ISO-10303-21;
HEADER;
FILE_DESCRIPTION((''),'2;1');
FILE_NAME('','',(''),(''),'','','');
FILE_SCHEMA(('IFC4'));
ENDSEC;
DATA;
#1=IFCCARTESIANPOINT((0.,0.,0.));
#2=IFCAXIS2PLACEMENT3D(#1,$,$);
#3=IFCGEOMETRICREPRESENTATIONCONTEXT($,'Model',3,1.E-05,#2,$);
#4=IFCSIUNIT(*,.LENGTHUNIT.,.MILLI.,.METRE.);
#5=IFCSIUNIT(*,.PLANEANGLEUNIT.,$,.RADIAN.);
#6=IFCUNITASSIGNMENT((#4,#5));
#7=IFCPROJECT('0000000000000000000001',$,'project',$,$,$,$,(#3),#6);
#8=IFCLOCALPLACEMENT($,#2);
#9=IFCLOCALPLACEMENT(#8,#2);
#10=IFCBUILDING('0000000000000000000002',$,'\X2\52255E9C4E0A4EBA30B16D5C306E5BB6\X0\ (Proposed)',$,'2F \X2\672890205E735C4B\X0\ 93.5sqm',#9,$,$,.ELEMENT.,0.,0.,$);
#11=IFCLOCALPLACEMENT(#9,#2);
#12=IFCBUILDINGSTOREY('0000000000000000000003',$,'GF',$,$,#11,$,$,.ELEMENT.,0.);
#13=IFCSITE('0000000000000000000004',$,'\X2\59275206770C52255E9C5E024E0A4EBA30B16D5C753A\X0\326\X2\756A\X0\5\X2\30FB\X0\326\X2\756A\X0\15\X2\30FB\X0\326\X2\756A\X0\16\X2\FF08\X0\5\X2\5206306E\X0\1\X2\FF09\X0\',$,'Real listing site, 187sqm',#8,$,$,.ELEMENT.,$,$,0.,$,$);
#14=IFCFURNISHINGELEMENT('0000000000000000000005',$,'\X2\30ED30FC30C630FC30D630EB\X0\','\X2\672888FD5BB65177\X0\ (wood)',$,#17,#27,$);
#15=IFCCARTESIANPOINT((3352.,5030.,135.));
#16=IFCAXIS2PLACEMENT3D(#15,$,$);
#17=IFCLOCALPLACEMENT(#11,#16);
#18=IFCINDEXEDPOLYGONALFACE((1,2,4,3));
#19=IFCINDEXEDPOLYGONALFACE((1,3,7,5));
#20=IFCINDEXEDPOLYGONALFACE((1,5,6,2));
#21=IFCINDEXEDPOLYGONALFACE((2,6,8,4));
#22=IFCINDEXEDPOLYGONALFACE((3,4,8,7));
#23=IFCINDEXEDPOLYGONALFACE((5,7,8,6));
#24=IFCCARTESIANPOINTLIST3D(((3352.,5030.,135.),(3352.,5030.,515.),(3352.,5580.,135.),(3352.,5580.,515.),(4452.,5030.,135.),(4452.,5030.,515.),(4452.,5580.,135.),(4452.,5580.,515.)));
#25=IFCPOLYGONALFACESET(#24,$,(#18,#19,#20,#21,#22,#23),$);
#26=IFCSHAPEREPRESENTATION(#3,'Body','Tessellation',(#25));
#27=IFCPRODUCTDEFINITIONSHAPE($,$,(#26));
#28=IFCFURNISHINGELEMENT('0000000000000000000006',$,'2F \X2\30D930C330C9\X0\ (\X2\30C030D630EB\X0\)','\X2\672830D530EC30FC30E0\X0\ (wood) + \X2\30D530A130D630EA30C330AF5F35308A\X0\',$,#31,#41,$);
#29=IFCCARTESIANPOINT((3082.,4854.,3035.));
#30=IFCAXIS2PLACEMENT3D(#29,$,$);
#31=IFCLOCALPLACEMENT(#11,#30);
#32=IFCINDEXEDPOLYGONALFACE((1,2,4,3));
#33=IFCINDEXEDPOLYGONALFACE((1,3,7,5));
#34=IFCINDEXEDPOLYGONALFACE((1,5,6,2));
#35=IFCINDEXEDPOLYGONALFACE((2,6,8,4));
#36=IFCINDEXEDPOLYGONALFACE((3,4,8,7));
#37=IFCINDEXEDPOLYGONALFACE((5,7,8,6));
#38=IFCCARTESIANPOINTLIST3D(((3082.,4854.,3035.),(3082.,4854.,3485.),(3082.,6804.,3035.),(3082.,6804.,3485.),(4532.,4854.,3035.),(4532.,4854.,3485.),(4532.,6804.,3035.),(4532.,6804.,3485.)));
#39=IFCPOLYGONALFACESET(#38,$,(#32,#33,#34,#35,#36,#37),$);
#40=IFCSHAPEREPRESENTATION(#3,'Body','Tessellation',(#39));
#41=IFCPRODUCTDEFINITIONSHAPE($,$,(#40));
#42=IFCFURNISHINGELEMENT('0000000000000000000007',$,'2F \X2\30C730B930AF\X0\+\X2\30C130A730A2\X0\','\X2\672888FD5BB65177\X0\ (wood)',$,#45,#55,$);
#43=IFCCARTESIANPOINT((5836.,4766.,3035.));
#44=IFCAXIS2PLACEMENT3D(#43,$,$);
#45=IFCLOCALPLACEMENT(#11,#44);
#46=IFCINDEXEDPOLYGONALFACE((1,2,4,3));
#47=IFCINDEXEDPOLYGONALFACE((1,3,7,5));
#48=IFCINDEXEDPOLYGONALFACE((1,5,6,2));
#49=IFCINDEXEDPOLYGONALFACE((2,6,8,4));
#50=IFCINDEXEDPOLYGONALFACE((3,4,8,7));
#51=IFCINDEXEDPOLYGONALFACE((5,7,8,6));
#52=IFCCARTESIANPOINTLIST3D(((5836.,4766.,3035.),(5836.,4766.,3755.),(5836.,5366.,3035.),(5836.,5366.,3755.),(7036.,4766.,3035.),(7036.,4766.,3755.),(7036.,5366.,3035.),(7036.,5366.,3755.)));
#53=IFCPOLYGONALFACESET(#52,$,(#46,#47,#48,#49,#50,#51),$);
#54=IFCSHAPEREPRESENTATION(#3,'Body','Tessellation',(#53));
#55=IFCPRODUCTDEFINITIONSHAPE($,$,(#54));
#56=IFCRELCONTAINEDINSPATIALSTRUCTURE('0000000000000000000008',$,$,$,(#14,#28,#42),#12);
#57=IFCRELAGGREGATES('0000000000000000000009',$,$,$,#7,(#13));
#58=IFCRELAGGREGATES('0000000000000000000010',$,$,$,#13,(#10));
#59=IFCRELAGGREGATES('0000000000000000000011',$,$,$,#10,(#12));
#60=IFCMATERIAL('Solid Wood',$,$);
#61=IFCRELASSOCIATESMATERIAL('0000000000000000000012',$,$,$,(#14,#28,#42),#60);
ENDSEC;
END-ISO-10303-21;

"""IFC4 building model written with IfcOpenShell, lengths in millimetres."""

from ifc_helpers import new_model, si_unit, frame, frame_2d, origin, place, context, project, spatial, rectangle, extrude, material, element, save


model = new_model("IFC4")

# Units and contexts
model_context = context("Model", 3, precision=1e-05, world=origin())
ifc_project = project(units=[si_unit("LENGTHUNIT", "METRE", prefix="MILLI"), si_unit("PLANEANGLEUNIT", "RADIAN")], contexts=[model_context])

# Site, building, storey
site_placement = place(None, origin())
site = spatial("IfcSite", under=ifc_project, at=site_placement, Name="大分県別府市上人ケ浜町326番5・326番15・326番16（5分の1）", ObjectType="Real listing site, 187sqm", CompositionType="ELEMENT", RefElevation=0.0)
building_placement = place(site_placement, origin())
building = spatial("IfcBuilding", under=site, at=building_placement, Name="別府上人ケ浜の家 (Proposed)", ObjectType="2F 木造平屋 93.5sqm", CompositionType="ELEMENT", ElevationOfRefHeight=0.0, ElevationOfTerrain=0.0)
storey_placement = place(building_placement, origin())
storey = spatial("IfcBuildingStorey", under=building, at=storey_placement, Name="GF", CompositionType="ELEMENT", Elevation=0.0)

# Shared definitions
ifc_material_1 = material(Name="Solid Wood")

# Furnishing elements
furnishing_1_placement = place(storey_placement, frame((3352.0, 5030.0, 135.0)))
element("IfcFurnishingElement", 1, at=furnishing_1_placement, inside=storey, material=ifc_material_1, Name="ローテーブル", Description="木製家具 (wood)", context=model_context, shape_type="SweptSolid", body=[
    extrude(rectangle(XDim=1100.0, YDim=550.0, at=frame_2d((550.0, 275.0))), frame((3352.0, 5030.0, 135.0)), (0.0, 0.0, 1.0), 380.0),
])
furnishing_2_placement = place(storey_placement, frame((3082.0, 4854.0, 3035.0)))
element("IfcFurnishingElement", 2, at=furnishing_2_placement, inside=storey, material=ifc_material_1, Name="2F ベッド (ダブル)", Description="木フレーム (wood) + ファブリック張り", context=model_context, shape_type="SweptSolid", body=[
    extrude(rectangle(XDim=1450.0, YDim=1950.0, at=frame_2d((725.0, 975.0))), frame((3082.0, 4854.0, 3035.0)), (0.0, 0.0, 1.0), 450.0),
])
furnishing_3_placement = place(storey_placement, frame((5836.0, 4766.0, 3035.0)))
element("IfcFurnishingElement", 3, at=furnishing_3_placement, inside=storey, material=ifc_material_1, Name="2F デスク+チェア", Description="木製家具 (wood)", context=model_context, shape_type="SweptSolid", body=[
    extrude(rectangle(XDim=1200.0, YDim=600.0, at=frame_2d((600.0, 300.0))), frame((5836.0, 4766.0, 3035.0)), (0.0, 0.0, 1.0), 720.0),
])

save(model, "model.ifc")
